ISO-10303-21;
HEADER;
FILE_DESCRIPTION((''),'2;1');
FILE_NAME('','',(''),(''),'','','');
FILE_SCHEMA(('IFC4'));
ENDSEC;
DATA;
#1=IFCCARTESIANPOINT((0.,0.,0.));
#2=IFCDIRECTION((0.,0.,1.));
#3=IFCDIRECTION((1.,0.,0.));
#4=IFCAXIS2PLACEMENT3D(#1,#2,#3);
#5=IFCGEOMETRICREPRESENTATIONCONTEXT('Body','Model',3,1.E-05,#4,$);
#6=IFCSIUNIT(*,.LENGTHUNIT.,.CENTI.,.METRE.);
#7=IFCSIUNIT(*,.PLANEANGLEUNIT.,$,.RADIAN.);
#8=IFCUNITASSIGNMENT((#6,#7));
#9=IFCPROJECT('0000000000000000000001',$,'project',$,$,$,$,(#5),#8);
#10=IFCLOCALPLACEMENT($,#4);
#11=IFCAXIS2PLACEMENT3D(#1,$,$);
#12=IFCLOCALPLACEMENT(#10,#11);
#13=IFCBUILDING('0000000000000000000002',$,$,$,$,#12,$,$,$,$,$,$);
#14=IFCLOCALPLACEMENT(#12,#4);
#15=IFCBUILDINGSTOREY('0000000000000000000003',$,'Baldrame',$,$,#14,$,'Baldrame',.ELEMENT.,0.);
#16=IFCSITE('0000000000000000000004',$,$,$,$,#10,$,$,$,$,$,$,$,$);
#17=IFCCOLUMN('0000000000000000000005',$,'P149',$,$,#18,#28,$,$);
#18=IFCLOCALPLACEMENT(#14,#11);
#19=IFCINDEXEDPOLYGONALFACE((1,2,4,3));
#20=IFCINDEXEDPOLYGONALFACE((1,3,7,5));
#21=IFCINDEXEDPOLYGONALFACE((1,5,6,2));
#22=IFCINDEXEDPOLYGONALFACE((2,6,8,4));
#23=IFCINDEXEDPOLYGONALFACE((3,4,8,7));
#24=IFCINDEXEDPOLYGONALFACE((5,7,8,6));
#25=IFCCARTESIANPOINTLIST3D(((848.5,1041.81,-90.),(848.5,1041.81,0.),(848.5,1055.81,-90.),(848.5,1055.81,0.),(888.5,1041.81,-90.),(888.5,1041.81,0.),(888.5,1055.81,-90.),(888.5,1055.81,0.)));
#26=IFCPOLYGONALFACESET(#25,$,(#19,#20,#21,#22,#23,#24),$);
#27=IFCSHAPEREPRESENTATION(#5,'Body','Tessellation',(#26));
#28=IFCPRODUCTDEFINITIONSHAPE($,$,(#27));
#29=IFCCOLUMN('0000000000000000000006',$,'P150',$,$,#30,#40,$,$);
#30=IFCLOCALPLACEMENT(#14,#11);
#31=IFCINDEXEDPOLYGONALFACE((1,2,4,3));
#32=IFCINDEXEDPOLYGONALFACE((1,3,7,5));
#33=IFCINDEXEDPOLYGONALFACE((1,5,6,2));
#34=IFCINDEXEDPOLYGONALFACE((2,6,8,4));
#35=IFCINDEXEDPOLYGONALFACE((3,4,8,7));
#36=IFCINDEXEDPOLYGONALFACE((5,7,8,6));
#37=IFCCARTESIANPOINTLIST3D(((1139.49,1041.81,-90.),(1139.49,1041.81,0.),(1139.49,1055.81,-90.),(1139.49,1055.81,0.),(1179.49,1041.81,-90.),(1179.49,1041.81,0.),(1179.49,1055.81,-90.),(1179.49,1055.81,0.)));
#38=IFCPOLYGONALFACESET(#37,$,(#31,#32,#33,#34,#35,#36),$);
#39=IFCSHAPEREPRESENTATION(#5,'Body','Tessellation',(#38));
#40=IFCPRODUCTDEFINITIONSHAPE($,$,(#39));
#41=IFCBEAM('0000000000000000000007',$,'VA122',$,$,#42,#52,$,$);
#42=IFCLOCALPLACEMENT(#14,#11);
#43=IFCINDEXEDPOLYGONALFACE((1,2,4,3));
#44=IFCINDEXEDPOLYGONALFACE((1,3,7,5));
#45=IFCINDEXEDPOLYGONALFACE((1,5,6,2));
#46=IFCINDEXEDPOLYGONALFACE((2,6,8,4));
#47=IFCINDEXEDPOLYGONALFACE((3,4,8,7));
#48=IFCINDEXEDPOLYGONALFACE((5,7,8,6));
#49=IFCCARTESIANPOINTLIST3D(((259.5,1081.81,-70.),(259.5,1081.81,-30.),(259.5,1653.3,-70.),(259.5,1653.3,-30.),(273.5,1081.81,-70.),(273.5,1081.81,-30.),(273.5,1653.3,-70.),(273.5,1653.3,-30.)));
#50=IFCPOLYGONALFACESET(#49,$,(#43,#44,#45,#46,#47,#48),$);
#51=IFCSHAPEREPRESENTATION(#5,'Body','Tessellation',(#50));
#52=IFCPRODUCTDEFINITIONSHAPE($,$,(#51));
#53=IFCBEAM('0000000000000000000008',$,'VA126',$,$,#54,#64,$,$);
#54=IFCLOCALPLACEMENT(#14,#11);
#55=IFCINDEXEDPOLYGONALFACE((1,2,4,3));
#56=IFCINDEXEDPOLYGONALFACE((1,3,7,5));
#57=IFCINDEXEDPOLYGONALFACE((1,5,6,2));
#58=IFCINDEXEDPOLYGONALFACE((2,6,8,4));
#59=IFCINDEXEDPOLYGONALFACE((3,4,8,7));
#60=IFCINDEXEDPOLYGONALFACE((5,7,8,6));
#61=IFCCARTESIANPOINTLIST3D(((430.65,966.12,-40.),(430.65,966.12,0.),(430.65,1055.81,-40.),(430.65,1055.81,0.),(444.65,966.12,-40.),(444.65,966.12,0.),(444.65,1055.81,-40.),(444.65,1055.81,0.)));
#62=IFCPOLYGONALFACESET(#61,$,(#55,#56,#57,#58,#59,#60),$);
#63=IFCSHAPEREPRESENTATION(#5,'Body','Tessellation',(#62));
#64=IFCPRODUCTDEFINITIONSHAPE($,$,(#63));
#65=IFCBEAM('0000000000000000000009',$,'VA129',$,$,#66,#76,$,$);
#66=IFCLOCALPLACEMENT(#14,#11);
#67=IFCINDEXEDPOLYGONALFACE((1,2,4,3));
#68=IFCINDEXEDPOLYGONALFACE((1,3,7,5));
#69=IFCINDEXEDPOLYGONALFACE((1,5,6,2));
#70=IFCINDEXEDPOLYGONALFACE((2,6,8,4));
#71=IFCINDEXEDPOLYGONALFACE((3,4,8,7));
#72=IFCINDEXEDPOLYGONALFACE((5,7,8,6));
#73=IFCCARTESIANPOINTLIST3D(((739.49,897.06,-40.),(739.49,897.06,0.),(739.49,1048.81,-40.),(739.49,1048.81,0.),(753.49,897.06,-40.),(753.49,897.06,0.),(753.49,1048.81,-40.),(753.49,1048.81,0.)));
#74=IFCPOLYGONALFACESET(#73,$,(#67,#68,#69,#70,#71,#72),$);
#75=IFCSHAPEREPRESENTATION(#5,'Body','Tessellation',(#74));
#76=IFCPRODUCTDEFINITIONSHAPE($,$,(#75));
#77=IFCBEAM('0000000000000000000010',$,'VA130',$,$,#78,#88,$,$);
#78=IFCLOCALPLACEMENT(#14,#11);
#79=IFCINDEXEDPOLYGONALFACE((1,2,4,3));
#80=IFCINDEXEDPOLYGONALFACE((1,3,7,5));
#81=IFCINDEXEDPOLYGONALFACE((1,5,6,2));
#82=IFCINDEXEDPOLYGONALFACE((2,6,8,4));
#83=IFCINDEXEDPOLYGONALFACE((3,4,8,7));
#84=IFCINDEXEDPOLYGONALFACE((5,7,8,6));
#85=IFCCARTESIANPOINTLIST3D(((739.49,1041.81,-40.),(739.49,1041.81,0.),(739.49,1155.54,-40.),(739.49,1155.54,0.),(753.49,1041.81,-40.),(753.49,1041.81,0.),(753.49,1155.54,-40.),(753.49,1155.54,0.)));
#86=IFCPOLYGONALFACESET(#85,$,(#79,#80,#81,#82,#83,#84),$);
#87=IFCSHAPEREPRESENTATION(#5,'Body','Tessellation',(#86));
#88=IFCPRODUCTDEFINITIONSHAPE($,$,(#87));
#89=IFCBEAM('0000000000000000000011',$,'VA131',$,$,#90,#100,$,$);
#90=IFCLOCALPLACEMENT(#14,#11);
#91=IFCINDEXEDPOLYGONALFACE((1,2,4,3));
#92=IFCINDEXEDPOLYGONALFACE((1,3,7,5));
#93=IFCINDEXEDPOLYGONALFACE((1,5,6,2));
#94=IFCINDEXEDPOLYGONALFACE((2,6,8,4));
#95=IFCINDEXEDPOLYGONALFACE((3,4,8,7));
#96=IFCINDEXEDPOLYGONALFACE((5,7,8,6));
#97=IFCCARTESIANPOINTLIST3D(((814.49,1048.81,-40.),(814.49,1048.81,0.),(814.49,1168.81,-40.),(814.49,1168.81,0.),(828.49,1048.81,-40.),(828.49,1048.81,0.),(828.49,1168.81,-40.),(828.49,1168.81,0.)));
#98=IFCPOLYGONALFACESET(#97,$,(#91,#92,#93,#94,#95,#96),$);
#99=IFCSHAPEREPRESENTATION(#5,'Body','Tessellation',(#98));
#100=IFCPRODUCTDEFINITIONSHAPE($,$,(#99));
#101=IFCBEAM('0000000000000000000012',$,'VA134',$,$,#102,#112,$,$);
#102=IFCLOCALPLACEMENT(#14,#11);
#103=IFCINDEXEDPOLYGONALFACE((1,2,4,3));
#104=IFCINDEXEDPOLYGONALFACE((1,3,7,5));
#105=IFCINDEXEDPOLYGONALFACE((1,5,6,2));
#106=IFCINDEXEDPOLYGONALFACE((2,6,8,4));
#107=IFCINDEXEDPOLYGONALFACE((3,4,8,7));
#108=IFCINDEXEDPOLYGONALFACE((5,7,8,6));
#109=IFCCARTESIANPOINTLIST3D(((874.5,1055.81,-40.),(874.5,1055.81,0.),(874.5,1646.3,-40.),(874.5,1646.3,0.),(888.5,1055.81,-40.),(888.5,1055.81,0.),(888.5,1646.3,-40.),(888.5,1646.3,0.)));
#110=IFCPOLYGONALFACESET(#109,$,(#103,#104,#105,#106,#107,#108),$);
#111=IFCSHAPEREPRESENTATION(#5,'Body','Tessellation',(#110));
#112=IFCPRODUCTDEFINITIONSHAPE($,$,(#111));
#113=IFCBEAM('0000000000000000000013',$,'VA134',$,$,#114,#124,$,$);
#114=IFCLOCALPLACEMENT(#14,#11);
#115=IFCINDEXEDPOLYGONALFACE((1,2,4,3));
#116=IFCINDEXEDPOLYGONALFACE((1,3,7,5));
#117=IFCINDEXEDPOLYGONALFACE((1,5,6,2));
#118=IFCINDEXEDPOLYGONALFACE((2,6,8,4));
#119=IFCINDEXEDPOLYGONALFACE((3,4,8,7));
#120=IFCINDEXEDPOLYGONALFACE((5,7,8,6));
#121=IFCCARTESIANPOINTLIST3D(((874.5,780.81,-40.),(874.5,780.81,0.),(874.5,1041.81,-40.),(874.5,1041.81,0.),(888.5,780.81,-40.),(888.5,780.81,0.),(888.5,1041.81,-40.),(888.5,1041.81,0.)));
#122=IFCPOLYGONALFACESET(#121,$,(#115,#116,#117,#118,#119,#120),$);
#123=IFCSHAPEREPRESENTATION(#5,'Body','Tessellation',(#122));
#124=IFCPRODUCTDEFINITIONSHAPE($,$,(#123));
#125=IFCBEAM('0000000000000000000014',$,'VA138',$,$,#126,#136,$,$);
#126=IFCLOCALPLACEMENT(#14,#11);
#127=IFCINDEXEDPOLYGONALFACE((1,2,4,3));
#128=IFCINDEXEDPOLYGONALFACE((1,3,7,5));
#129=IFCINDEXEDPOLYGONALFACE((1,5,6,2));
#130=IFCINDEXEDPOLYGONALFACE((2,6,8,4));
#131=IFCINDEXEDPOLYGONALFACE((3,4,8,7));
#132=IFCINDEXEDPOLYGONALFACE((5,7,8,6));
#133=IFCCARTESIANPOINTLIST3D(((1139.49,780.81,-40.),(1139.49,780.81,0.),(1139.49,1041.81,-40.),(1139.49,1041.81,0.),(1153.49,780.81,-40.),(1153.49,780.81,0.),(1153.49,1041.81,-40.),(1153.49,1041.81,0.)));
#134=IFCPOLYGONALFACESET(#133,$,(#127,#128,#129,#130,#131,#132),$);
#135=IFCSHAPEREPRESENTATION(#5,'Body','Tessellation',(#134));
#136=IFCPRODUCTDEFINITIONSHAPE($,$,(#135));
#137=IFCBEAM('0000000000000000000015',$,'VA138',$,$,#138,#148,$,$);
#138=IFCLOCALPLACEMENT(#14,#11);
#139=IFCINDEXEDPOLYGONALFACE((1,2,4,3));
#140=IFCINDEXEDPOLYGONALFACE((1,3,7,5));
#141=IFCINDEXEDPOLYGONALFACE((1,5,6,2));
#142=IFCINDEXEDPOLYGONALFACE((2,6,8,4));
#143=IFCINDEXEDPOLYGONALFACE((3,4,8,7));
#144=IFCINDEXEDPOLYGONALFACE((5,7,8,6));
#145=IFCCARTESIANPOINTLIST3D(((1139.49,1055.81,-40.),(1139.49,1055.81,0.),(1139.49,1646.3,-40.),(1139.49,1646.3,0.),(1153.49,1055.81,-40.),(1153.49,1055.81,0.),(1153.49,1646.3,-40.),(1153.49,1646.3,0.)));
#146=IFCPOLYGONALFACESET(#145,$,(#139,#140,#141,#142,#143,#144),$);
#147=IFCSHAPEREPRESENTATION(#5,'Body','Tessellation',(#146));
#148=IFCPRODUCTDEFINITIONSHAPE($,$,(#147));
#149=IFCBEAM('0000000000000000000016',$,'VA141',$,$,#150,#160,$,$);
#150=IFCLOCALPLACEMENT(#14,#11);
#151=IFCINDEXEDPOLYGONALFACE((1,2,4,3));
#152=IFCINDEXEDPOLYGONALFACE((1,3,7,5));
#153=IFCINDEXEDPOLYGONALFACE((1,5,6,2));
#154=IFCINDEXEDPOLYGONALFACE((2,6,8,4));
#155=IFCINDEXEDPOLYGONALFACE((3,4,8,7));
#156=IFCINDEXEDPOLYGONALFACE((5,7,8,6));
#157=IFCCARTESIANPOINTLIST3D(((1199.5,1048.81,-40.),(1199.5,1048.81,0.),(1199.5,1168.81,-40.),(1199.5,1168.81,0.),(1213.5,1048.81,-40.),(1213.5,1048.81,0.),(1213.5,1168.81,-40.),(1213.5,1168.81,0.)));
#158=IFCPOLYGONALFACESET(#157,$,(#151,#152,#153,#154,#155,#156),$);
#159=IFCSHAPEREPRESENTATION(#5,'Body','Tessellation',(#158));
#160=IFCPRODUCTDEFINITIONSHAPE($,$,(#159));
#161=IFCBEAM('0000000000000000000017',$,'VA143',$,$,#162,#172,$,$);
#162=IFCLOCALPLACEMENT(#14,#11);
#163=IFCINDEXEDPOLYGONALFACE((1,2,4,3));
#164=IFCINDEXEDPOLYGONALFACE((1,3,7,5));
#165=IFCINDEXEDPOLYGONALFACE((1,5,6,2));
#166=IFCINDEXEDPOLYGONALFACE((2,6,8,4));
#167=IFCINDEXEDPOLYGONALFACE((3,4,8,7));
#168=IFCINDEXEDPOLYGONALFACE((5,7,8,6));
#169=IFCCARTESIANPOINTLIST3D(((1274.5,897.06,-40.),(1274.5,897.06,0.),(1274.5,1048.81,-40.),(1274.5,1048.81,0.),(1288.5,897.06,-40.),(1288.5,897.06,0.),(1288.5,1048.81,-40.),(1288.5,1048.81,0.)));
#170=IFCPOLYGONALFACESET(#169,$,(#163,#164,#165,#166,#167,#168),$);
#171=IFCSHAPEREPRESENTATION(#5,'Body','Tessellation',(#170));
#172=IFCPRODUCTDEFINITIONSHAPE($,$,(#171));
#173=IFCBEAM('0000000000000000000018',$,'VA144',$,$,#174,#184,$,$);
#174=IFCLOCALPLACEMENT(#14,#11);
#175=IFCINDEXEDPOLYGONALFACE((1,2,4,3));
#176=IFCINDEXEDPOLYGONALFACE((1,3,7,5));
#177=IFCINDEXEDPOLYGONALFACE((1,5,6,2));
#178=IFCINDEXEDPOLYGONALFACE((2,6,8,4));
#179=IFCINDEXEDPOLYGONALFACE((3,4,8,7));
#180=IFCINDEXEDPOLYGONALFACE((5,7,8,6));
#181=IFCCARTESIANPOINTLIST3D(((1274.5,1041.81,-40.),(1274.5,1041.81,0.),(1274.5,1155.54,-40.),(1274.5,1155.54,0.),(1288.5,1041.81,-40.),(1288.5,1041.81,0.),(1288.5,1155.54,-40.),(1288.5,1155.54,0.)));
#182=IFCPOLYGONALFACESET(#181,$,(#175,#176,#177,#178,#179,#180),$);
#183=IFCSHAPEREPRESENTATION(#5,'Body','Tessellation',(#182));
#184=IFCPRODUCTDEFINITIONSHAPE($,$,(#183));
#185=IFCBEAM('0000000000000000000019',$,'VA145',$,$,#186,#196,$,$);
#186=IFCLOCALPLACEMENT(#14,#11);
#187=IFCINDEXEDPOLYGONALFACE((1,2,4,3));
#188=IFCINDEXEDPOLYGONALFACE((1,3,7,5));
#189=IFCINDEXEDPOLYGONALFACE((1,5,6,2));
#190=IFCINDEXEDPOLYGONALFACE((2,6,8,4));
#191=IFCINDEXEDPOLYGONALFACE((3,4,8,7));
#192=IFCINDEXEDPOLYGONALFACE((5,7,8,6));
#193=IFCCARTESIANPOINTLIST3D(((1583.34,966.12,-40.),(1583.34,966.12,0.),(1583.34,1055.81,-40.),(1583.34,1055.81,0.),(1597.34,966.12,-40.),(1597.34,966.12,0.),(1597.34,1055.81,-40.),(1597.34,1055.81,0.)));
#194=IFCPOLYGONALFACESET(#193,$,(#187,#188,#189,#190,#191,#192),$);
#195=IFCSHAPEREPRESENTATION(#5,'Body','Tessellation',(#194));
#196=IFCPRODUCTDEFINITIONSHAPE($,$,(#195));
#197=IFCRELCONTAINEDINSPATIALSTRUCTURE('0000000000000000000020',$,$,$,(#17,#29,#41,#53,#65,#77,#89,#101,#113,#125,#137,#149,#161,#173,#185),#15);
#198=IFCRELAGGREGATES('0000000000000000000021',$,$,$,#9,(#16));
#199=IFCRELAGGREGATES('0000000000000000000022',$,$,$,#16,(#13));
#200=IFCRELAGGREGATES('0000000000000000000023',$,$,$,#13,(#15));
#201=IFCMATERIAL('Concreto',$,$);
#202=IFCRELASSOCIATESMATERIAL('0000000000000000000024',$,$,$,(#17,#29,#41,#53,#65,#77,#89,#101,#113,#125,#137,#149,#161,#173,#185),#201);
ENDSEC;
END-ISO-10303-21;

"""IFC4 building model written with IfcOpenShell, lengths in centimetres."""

from ifc_helpers import new_model, si_unit, frame, origin, origin_with_axes, origin_2d_with_axis, place, context, project, spatial, rectangle, extrude, material, element, save


model = new_model("IFC4")

# Units and contexts
model_context = context("Model", 3, precision=1e-05, world=origin_with_axes(), identifier="Body")
ifc_project = project(units=[si_unit("LENGTHUNIT", "METRE", prefix="CENTI"), si_unit("PLANEANGLEUNIT", "RADIAN")], contexts=[model_context])

# Site, building, storey
site_placement = place(None, origin_with_axes())
site = spatial("IfcSite", under=ifc_project, at=site_placement)
building_placement = place(site_placement, origin())
building = spatial("IfcBuilding", under=site, at=building_placement)
storey_placement = place(building_placement, origin_with_axes())
storey = spatial("IfcBuildingStorey", under=building, at=storey_placement, Name="Baldrame", LongName="Baldrame", CompositionType="ELEMENT", Elevation=0.0)

# Shared definitions
ifc_material = material(Name="Concreto")

# Columns
column_1_placement = place(storey_placement, frame((868.5, 1048.81, 0.0), z_axis=(0.0, 0.0, 1.0), x_axis=(1.0, 0.0, 0.0)))
element("IfcColumn", 1, at=column_1_placement, inside=storey, material=ifc_material, Name="P149", context=model_context, shape_type="SolidModel", body=[
    extrude(rectangle(XDim=14.0, YDim=40.0, at=origin_2d_with_axis()), frame((0.0, 0.0, -90.0), z_axis=(0.0, 0.0, 1.0), x_axis=(0.0, 1.0, 0.0)), (0.0, 0.0, 1.0), 90.0),
])
column_2_placement = place(storey_placement, frame((1159.49, 1048.81, 0.0), z_axis=(0.0, 0.0, 1.0), x_axis=(1.0, 0.0, 0.0)))
element("IfcColumn", 2, at=column_2_placement, inside=storey, material=ifc_material, Name="P150", context=model_context, shape_type="SolidModel", body=[
    extrude(rectangle(XDim=14.0, YDim=40.0, at=origin_2d_with_axis()), frame((0.0, 0.0, -90.0), z_axis=(0.0, 0.0, 1.0), x_axis=(0.0, -1.0, 0.0)), (0.0, 0.0, 1.0), 90.0),
])

# Beams
beam_1_placement = place(storey_placement, frame((266.5, 1367.56, -30.0), z_axis=(0.0, 0.0, 1.0), x_axis=(1.0, 0.0, 0.0)))
element("IfcBeam", 3, at=beam_1_placement, inside=storey, material=ifc_material, Name="VA122", context=model_context, shape_type="SolidModel", body=[
    extrude(rectangle(XDim=14.0, YDim=40.0, at=origin_2d_with_axis()), frame((0.0, -285.75, -20.0), z_axis=(0.0, 1.0, 0.0), x_axis=(-1.0, 0.0, 0.0)), (0.0, 0.0, 1.0), 571.49),
])
beam_2_placement = place(storey_placement, frame((437.65, 1010.96, 0.0), z_axis=(0.0, 0.0, 1.0), x_axis=(1.0, 0.0, 0.0)))
element("IfcBeam", 4, at=beam_2_placement, inside=storey, material=ifc_material, Name="VA126", context=model_context, shape_type="SolidModel", body=[
    extrude(rectangle(XDim=14.0, YDim=40.0, at=origin_2d_with_axis()), frame((0.0, -44.85, -20.0), z_axis=(0.0, 1.0, 0.0), x_axis=(-1.0, 0.0, 0.0)), (0.0, 0.0, 1.0), 89.69),
])
beam_3_placement = place(storey_placement, frame((746.49, 972.93, 0.0), z_axis=(0.0, 0.0, 1.0), x_axis=(1.0, 0.0, 0.0)))
element("IfcBeam", 5, at=beam_3_placement, inside=storey, material=ifc_material, Name="VA129", context=model_context, shape_type="SolidModel", body=[
    extrude(rectangle(XDim=14.0, YDim=40.0, at=origin_2d_with_axis()), frame((0.0, -75.88, -20.0), z_axis=(0.0, 1.0, 0.0), x_axis=(1.0, 0.0, 0.0)), (0.0, 0.0, 1.0), 151.75),
])
beam_4_placement = place(storey_placement, frame((746.49, 1098.68, 0.0), z_axis=(0.0, 0.0, 1.0), x_axis=(1.0, 0.0, 0.0)))
element("IfcBeam", 6, at=beam_4_placement, inside=storey, material=ifc_material, Name="VA130", context=model_context, shape_type="SolidModel", body=[
    extrude(rectangle(XDim=14.0, YDim=40.0, at=origin_2d_with_axis()), frame((0.0, -56.87, -20.0), z_axis=(0.0, 1.0, 0.0), x_axis=(1.0, 0.0, 0.0)), (0.0, 0.0, 1.0), 113.73),
])
beam_5_placement = place(storey_placement, frame((821.49, 1108.81, 0.0), z_axis=(0.0, 0.0, 1.0), x_axis=(1.0, 0.0, 0.0)))
element("IfcBeam", 7, at=beam_5_placement, inside=storey, material=ifc_material, Name="VA131", context=model_context, shape_type="SolidModel", body=[
    extrude(rectangle(XDim=14.0, YDim=40.0, at=origin_2d_with_axis()), frame((0.0, -60.0, -20.0), z_axis=(0.0, 1.0, 0.0), x_axis=(1.0, 0.0, 0.0)), (0.0, 0.0, 1.0), 120.0),
])
beam_6_placement = place(storey_placement, frame((881.5, 1351.06, 0.0), z_axis=(0.0, 0.0, 1.0), x_axis=(1.0, 0.0, 0.0)))
element("IfcBeam", 8, at=beam_6_placement, inside=storey, material=ifc_material, Name="VA134", context=model_context, shape_type="SolidModel", body=[
    extrude(rectangle(XDim=14.0, YDim=40.0, at=origin_2d_with_axis()), frame((0.0, -295.25, -20.0), z_axis=(0.0, 1.0, 0.0), x_axis=(1.0, 0.0, 0.0)), (0.0, 0.0, 1.0), 590.49),
])
for number, where, z_axis, x_axis, name in (
    (9, (881.5, 911.31, 0.0), (0.0, 0.0, 1.0), (1.0, 0.0, 0.0), "VA134"),
    (10, (1146.49, 911.31, 0.0), (0.0, 0.0, 1.0), (1.0, 0.0, 0.0), "VA138"),
):
    element("IfcBeam", number, at=place(storey_placement, frame(where, z_axis=z_axis, x_axis=x_axis)), inside=storey, material=ifc_material, Name=name, context=model_context, shape_type="SolidModel", body=[
        extrude(rectangle(XDim=14.0, YDim=40.0, at=origin_2d_with_axis()), frame((0.0, -130.5, -20.0), z_axis=(0.0, 1.0, 0.0), x_axis=(1.0, 0.0, 0.0)), (0.0, 0.0, 1.0), 261.0),
    ])
beam_7_placement = place(storey_placement, frame((1146.49, 1351.06, 0.0), z_axis=(0.0, 0.0, 1.0), x_axis=(1.0, 0.0, 0.0)))
element("IfcBeam", 11, at=beam_7_placement, inside=storey, material=ifc_material, Name="VA138", context=model_context, shape_type="SolidModel", body=[
    extrude(rectangle(XDim=14.0, YDim=40.0, at=origin_2d_with_axis()), frame((0.0, -295.25, -20.0), z_axis=(0.0, 1.0, 0.0), x_axis=(1.0, 0.0, 0.0)), (0.0, 0.0, 1.0), 590.49),
])
beam_8_placement = place(storey_placement, frame((1206.5, 1108.81, 0.0), z_axis=(0.0, 0.0, 1.0), x_axis=(1.0, 0.0, 0.0)))
element("IfcBeam", 12, at=beam_8_placement, inside=storey, material=ifc_material, Name="VA141", context=model_context, shape_type="SolidModel", body=[
    extrude(rectangle(XDim=14.0, YDim=40.0, at=origin_2d_with_axis()), frame((0.0, -60.0, -20.0), z_axis=(0.0, 1.0, 0.0), x_axis=(1.0, 0.0, 0.0)), (0.0, 0.0, 1.0), 120.0),
])
beam_9_placement = place(storey_placement, frame((1281.5, 972.93, 0.0), z_axis=(0.0, 0.0, 1.0), x_axis=(1.0, 0.0, 0.0)))
element("IfcBeam", 13, at=beam_9_placement, inside=storey, material=ifc_material, Name="VA143", context=model_context, shape_type="SolidModel", body=[
    extrude(rectangle(XDim=14.0, YDim=40.0, at=origin_2d_with_axis()), frame((0.0, -75.88, -20.0), z_axis=(0.0, 1.0, 0.0), x_axis=(1.0, 0.0, 0.0)), (0.0, 0.0, 1.0), 151.75),
])
beam_10_placement = place(storey_placement, frame((1281.5, 1098.68, 0.0), z_axis=(0.0, 0.0, 1.0), x_axis=(1.0, 0.0, 0.0)))
element("IfcBeam", 14, at=beam_10_placement, inside=storey, material=ifc_material, Name="VA144", context=model_context, shape_type="SolidModel", body=[
    extrude(rectangle(XDim=14.0, YDim=40.0, at=origin_2d_with_axis()), frame((0.0, -56.87, -20.0), z_axis=(0.0, 1.0, 0.0), x_axis=(1.0, 0.0, 0.0)), (0.0, 0.0, 1.0), 113.73),
])
beam_11_placement = place(storey_placement, frame((1590.34, 1010.96, 0.0), z_axis=(0.0, 0.0, 1.0), x_axis=(1.0, 0.0, 0.0)))
element("IfcBeam", 15, at=beam_11_placement, inside=storey, material=ifc_material, Name="VA145", context=model_context, shape_type="SolidModel", body=[
    extrude(rectangle(XDim=14.0, YDim=40.0, at=origin_2d_with_axis()), frame((0.0, -44.85, -20.0), z_axis=(0.0, 1.0, 0.0), x_axis=(1.0, 0.0, 0.0)), (0.0, 0.0, 1.0), 89.69),
])

save(model, "model.ifc")
